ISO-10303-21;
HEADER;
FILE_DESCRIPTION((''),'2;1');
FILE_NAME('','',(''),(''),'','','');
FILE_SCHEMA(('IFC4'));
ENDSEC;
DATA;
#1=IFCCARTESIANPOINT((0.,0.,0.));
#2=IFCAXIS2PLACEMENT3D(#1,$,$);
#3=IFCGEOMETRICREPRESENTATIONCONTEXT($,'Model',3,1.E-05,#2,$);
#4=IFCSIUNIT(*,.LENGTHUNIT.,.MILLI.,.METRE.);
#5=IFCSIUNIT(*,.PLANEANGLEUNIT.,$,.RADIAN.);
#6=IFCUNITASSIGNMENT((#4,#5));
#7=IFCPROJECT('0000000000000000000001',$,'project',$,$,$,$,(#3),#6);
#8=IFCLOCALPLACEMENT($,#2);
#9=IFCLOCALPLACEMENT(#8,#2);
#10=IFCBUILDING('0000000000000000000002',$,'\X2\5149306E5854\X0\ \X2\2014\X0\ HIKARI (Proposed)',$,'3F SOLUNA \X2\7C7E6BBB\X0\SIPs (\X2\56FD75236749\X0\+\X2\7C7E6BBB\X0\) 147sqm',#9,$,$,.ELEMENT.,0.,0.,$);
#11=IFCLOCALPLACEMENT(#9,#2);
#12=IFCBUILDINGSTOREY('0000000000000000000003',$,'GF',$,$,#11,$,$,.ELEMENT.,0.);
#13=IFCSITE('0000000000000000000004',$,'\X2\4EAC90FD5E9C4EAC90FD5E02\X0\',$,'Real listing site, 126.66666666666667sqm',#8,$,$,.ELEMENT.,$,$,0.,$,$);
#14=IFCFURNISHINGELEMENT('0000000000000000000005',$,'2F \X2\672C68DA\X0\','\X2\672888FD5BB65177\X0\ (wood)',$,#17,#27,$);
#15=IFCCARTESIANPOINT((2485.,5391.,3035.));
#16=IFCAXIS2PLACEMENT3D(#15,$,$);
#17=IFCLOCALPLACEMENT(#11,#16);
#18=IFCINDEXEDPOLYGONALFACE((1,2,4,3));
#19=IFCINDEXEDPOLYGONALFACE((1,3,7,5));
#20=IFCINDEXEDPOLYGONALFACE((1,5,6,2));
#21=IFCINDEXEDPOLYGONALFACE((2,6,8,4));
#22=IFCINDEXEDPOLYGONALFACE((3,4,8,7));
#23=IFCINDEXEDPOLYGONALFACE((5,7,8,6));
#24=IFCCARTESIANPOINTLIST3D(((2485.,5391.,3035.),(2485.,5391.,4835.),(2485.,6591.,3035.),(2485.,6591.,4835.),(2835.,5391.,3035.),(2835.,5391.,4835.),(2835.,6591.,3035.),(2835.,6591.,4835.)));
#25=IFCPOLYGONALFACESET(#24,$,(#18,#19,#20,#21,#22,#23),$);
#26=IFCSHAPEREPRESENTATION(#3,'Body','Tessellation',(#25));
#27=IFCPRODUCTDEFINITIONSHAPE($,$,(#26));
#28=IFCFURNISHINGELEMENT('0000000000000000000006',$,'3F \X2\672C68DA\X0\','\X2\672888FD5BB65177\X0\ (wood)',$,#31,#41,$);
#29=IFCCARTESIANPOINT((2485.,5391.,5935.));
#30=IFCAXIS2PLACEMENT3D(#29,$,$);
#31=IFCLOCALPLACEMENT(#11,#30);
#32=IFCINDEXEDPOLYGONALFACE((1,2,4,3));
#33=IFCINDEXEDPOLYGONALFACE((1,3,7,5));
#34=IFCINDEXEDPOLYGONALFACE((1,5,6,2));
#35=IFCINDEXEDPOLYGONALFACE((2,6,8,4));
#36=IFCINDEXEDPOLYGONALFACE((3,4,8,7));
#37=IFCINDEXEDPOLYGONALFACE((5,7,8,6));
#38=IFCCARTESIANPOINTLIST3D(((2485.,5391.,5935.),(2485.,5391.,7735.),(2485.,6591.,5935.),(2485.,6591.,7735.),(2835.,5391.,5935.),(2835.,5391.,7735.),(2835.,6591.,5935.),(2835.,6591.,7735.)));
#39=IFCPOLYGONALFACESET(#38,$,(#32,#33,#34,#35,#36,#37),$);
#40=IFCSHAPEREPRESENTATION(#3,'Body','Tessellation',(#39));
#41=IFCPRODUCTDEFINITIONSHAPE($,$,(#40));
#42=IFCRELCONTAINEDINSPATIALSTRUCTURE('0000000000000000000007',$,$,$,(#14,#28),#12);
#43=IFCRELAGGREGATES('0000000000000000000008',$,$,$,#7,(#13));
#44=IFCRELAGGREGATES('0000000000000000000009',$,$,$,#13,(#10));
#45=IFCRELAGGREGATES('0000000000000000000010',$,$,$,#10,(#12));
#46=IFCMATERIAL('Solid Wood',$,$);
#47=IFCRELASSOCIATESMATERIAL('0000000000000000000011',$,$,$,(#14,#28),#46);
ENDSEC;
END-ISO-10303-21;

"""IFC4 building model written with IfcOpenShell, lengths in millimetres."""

from ifc_helpers import new_model, si_unit, frame, frame_2d, origin, place, context, project, spatial, rectangle, extrude, material, element, save


model = new_model("IFC4")

# Units and contexts
model_context = context("Model", 3, precision=1e-05, world=origin())
ifc_project = project(units=[si_unit("LENGTHUNIT", "METRE", prefix="MILLI"), si_unit("PLANEANGLEUNIT", "RADIAN")], contexts=[model_context])

# Site, building, storey
site_placement = place(None, origin())
site = spatial("IfcSite", under=ifc_project, at=site_placement, Name="京都府京都市", ObjectType="Real listing site, 126.66666666666667sqm", CompositionType="ELEMENT", RefElevation=0.0)
building_placement = place(site_placement, origin())
building = spatial("IfcBuilding", under=site, at=building_placement, Name="光の塔 — HIKARI (Proposed)", ObjectType="3F SOLUNA 籾殻SIPs (国産杉+籾殻) 147sqm", CompositionType="ELEMENT", ElevationOfRefHeight=0.0, ElevationOfTerrain=0.0)
storey_placement = place(building_placement, origin())
storey = spatial("IfcBuildingStorey", under=building, at=storey_placement, Name="GF", CompositionType="ELEMENT", Elevation=0.0)

# Shared definitions
ifc_material_1 = material(Name="Solid Wood")

# Furnishing elements
furnishing_1_placement = place(storey_placement, frame((2485.0, 5391.0, 3035.0)))
element("IfcFurnishingElement", 1, at=furnishing_1_placement, inside=storey, material=ifc_material_1, Name="2F 本棚", Description="木製家具 (wood)", context=model_context, shape_type="SweptSolid", body=[
    extrude(rectangle(XDim=350.0, YDim=1200.0, at=frame_2d((175.0, 600.0))), frame((2485.0, 5391.0, 3035.0)), (0.0, 0.0, 1.0), 1800.0),
])
furnishing_2_placement = place(storey_placement, frame((2485.0, 5391.0, 5935.0)))
element("IfcFurnishingElement", 2, at=furnishing_2_placement, inside=storey, material=ifc_material_1, Name="3F 本棚", Description="木製家具 (wood)", context=model_context, shape_type="SweptSolid", body=[
    extrude(rectangle(XDim=350.0, YDim=1200.0, at=frame_2d((175.0, 600.0))), frame((2485.0, 5391.0, 5935.0)), (0.0, 0.0, 1.0), 1800.0),
])

save(model, "model.ifc")
